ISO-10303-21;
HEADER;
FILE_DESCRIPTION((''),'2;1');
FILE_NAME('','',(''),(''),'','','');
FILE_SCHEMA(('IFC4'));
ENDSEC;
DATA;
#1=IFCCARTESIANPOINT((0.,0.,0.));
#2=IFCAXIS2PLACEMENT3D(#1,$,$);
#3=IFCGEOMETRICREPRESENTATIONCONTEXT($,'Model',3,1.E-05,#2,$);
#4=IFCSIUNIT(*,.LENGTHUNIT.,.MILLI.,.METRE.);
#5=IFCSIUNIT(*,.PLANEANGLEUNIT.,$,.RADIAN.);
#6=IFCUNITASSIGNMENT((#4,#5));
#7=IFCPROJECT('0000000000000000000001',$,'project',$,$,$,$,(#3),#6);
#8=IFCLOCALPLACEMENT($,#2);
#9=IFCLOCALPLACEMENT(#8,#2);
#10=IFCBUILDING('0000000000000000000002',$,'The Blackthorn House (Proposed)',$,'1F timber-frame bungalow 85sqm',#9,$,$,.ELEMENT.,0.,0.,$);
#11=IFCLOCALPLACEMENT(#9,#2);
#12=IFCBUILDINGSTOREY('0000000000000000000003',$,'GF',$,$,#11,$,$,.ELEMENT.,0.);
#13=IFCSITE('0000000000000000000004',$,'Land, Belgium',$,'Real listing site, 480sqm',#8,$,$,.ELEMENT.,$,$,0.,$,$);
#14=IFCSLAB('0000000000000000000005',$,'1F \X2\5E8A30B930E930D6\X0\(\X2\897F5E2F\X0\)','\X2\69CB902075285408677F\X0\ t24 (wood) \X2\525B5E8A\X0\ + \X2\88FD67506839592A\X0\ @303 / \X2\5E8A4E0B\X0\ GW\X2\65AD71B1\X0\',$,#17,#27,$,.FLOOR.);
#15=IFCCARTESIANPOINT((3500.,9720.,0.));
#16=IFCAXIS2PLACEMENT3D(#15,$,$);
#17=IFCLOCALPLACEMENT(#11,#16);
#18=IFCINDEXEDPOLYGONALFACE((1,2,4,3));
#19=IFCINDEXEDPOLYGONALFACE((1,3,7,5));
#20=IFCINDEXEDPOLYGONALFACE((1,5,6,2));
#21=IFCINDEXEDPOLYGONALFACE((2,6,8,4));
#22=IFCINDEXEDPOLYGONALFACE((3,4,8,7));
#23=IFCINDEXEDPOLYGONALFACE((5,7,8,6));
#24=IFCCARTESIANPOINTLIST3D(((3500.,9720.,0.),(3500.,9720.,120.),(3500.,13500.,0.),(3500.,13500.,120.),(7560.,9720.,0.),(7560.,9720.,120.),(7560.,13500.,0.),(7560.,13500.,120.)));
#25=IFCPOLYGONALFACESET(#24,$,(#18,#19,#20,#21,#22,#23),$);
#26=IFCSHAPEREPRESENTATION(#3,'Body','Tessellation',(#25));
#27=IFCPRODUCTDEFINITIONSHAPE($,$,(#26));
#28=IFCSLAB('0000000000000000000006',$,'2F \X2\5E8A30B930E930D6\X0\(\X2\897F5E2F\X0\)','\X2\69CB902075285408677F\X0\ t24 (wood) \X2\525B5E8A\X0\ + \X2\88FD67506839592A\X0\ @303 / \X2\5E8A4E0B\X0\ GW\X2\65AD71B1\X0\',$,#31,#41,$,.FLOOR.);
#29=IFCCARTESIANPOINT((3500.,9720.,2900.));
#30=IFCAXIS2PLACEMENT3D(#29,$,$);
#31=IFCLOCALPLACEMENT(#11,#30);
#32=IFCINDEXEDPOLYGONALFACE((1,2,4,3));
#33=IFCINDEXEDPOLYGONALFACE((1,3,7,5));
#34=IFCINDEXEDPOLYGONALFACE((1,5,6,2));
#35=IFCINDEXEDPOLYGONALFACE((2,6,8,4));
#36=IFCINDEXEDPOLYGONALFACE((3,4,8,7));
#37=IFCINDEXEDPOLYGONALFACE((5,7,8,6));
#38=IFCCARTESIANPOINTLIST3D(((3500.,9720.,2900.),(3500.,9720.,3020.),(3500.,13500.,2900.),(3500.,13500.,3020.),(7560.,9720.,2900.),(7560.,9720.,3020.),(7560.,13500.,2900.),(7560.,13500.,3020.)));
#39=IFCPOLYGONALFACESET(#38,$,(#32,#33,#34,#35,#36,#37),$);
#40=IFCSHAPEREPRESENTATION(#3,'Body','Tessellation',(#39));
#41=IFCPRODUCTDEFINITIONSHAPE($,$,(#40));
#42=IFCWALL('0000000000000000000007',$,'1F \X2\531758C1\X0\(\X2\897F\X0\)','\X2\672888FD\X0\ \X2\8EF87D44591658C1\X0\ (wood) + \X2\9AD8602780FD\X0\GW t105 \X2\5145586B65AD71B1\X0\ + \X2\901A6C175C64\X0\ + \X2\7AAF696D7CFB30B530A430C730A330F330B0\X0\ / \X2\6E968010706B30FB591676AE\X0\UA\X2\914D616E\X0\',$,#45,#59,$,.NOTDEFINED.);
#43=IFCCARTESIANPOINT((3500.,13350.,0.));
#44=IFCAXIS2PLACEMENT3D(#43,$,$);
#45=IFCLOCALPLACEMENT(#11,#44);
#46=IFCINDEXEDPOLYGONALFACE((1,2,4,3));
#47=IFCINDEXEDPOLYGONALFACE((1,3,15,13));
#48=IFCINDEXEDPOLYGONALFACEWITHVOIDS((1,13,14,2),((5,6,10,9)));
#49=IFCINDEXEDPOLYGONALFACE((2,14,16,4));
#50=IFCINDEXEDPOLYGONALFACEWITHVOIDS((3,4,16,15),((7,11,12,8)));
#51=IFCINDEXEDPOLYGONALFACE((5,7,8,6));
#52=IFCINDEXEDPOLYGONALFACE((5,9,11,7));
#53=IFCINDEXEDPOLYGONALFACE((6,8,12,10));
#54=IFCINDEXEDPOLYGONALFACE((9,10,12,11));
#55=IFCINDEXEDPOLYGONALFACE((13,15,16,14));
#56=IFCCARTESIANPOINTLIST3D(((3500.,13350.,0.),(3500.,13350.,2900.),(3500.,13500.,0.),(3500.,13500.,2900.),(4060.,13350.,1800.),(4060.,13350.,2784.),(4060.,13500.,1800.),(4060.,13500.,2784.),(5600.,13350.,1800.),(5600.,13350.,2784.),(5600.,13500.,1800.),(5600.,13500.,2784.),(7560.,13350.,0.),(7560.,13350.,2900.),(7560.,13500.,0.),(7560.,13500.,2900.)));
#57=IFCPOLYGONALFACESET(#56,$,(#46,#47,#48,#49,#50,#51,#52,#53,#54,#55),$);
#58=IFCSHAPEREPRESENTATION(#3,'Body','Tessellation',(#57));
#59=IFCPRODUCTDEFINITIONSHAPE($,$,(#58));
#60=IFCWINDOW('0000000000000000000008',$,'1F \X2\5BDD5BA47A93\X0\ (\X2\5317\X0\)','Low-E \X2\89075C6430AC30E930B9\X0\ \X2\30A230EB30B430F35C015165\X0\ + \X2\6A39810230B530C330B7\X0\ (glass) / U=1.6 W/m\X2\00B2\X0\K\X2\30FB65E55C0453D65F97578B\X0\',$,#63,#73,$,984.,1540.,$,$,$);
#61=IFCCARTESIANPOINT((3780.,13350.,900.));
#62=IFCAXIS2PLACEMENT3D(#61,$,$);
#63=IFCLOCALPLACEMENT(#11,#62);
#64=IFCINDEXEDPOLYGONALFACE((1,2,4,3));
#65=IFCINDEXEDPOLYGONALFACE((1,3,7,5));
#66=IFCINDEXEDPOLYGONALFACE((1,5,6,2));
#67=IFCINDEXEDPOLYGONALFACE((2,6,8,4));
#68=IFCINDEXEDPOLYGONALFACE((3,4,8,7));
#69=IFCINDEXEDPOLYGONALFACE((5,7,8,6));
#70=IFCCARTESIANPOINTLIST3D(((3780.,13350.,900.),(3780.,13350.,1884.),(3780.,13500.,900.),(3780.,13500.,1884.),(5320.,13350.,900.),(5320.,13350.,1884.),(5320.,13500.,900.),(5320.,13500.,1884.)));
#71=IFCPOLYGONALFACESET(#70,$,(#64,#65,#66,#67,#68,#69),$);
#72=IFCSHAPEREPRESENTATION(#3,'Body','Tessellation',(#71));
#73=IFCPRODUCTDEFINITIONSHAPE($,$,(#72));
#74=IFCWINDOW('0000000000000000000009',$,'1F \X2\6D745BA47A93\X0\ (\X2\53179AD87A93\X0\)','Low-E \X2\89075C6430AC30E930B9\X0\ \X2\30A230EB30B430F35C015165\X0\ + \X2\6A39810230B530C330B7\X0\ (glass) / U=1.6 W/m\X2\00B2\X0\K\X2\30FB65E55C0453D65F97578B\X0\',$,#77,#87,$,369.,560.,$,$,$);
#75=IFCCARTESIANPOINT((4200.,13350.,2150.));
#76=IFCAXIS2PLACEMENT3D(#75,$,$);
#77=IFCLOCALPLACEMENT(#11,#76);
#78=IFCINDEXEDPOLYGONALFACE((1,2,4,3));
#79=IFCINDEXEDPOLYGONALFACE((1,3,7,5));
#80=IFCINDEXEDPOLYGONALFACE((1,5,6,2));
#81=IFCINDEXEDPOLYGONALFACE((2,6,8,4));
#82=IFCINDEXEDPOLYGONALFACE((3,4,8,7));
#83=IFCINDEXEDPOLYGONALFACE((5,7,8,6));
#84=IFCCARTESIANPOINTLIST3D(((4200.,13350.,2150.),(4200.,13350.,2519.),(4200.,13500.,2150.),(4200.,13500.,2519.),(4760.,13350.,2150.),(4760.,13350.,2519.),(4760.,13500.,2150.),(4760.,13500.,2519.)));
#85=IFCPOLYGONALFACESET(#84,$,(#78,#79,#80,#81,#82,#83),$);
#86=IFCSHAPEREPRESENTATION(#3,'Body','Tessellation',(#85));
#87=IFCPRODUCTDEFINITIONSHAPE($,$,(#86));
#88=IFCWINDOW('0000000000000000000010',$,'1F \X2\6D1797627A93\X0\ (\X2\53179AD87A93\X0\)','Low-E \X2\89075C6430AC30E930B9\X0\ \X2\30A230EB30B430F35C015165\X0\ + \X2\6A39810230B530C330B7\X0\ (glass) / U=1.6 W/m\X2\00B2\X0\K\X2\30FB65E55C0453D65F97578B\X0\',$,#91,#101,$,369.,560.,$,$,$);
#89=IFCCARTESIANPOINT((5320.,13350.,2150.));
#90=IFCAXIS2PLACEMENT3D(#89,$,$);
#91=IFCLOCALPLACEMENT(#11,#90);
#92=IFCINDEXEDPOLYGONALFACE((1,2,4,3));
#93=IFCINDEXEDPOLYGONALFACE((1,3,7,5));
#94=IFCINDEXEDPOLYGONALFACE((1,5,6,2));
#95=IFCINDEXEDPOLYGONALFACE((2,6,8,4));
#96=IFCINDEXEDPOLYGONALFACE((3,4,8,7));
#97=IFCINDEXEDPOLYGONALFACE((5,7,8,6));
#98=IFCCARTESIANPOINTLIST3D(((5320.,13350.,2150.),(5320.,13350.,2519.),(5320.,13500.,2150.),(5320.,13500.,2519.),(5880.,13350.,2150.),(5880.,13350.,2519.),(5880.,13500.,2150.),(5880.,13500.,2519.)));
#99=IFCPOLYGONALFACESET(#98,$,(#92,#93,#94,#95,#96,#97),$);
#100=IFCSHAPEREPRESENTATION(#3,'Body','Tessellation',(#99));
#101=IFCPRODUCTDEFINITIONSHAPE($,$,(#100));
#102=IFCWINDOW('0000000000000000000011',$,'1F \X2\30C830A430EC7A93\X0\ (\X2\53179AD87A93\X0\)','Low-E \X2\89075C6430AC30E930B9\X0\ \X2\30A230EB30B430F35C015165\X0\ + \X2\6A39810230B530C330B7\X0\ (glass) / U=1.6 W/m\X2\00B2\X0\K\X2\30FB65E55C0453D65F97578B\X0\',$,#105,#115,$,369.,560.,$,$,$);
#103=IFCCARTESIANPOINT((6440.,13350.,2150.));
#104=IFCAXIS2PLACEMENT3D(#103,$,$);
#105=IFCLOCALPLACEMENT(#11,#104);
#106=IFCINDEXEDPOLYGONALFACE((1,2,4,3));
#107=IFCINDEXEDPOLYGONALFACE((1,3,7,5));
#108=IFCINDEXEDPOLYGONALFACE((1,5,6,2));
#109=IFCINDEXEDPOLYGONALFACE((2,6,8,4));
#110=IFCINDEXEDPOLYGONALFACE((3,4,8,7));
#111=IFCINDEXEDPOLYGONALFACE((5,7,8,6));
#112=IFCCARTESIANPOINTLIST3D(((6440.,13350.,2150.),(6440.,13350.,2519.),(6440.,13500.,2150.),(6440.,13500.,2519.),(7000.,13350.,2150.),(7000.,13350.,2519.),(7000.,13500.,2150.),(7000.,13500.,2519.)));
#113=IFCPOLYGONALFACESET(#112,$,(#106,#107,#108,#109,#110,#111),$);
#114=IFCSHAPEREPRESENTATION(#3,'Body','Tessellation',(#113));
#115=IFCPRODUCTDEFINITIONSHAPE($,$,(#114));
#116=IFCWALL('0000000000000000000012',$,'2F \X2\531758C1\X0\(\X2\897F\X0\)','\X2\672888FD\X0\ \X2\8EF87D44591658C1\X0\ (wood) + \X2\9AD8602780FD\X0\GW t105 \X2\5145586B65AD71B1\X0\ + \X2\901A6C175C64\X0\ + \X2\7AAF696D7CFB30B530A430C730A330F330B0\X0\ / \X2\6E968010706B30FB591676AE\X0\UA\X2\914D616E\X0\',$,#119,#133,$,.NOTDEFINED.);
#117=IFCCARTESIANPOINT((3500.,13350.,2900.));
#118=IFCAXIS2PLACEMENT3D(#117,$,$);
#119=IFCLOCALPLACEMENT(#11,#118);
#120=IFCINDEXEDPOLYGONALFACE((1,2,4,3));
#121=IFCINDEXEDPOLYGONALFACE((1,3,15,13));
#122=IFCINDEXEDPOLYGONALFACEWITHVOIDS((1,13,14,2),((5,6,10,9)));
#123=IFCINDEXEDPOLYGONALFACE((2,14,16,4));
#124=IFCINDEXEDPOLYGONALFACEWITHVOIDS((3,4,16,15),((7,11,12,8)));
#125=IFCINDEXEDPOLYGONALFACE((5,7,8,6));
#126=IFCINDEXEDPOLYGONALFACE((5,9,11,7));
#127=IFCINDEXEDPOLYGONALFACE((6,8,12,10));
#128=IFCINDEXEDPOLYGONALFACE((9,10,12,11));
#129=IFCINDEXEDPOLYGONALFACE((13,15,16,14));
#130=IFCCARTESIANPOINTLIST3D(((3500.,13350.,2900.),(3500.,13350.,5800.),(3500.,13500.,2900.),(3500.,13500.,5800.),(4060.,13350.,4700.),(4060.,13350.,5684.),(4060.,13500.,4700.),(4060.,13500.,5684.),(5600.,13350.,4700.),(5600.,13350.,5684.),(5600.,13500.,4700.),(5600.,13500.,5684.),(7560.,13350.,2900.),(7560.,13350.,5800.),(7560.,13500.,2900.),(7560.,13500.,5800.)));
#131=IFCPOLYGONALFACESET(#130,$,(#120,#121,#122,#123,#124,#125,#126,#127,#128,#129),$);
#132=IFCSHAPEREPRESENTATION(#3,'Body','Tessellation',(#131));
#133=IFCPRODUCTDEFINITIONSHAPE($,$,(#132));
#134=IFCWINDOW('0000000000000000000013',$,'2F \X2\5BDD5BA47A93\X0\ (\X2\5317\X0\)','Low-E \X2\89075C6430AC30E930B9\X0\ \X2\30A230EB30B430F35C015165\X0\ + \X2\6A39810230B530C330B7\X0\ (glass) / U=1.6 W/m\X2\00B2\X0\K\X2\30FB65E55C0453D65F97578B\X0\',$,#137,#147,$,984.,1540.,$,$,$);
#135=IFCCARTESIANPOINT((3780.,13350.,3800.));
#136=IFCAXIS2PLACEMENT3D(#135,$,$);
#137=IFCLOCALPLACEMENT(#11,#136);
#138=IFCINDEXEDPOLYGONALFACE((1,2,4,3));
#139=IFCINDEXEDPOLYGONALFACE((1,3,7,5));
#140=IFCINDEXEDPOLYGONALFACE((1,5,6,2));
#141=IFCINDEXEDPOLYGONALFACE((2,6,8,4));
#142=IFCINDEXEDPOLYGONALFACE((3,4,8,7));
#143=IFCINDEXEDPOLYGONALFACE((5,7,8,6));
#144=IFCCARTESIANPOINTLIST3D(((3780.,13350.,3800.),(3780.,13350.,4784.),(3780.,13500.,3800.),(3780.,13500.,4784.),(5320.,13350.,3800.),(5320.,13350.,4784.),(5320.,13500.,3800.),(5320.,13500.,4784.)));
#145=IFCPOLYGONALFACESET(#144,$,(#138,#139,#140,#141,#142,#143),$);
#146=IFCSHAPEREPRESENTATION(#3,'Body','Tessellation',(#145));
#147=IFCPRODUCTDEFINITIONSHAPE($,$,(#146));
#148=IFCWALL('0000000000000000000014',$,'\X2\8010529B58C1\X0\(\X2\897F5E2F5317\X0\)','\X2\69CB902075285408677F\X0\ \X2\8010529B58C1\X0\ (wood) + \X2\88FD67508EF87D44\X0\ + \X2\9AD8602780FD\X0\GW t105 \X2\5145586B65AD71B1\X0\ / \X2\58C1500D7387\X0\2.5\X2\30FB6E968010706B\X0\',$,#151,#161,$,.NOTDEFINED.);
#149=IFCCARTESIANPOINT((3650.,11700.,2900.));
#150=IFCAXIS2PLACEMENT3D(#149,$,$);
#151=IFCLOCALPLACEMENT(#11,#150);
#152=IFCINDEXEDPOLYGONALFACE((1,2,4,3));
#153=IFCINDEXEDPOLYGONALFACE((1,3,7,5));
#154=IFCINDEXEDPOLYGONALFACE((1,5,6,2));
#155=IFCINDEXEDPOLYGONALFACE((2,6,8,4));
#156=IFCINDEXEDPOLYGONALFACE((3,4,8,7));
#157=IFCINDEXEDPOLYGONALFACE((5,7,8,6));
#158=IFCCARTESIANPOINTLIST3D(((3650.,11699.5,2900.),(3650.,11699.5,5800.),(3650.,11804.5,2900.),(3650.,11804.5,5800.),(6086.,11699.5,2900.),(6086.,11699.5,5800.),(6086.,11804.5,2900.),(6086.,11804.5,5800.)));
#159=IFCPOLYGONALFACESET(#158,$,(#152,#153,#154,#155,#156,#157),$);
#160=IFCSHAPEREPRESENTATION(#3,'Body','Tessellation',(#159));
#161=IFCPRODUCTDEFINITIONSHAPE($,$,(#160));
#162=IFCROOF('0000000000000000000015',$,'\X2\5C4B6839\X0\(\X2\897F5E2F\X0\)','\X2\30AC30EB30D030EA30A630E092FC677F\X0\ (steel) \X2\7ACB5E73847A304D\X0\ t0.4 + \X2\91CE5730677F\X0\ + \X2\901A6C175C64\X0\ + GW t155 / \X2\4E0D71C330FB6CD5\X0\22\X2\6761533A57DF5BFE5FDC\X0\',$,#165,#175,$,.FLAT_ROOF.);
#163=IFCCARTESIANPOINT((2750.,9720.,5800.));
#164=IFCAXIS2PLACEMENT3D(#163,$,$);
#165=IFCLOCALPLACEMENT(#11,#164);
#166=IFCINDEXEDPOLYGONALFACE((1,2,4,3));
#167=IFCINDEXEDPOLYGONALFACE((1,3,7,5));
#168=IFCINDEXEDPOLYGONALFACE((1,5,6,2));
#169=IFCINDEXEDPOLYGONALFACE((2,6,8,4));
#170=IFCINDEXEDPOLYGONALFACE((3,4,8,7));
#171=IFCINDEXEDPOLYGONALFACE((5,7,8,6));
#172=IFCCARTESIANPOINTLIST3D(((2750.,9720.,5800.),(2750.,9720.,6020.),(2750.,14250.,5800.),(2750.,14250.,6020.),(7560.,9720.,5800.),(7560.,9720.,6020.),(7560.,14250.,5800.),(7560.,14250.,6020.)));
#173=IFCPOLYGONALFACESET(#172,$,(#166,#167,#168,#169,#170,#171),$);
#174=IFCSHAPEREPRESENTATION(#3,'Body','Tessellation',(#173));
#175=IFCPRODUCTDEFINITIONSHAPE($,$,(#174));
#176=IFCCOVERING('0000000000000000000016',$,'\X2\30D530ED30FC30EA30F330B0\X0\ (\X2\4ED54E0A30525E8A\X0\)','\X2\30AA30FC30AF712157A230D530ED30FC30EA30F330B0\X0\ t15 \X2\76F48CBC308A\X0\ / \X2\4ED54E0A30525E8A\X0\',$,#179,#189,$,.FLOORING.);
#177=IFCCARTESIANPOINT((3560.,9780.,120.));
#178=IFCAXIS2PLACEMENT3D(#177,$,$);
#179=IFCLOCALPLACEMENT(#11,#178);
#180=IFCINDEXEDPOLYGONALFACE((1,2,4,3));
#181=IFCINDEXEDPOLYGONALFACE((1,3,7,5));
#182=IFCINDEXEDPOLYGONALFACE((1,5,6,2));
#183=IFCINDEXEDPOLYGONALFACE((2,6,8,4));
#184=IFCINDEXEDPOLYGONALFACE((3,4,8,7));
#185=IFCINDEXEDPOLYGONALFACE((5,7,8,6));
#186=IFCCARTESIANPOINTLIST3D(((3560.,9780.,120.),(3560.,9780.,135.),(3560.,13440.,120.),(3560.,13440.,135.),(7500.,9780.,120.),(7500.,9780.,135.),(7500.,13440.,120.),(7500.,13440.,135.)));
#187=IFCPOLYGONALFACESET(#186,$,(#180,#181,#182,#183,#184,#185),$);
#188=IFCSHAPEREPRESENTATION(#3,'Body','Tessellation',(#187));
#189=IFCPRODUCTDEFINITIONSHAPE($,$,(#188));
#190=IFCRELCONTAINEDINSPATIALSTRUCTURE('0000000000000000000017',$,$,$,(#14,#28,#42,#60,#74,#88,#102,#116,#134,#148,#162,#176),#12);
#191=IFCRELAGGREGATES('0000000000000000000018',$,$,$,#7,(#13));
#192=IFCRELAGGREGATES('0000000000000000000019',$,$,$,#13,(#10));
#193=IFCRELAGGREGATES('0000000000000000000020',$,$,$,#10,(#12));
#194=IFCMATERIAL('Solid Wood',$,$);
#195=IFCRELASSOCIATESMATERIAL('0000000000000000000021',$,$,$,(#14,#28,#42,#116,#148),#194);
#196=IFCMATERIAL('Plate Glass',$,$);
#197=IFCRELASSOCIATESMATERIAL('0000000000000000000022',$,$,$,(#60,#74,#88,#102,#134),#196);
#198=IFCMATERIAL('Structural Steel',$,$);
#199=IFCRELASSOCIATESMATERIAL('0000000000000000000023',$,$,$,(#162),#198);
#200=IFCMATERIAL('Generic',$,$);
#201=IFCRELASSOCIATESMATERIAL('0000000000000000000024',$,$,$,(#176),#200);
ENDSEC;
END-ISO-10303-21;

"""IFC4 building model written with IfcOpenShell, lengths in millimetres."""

from ifc_helpers import new_model, si_unit, frame, frame_2d, origin, place, context, project, spatial, rectangle, extrude, material, element, fill, save


model = new_model("IFC4")

# Units and contexts
model_context = context("Model", 3, precision=1e-05, world=origin())
ifc_project = project(units=[si_unit("LENGTHUNIT", "METRE", prefix="MILLI"), si_unit("PLANEANGLEUNIT", "RADIAN")], contexts=[model_context])

# Site, building, storey
site_placement = place(None, origin())
site = spatial("IfcSite", under=ifc_project, at=site_placement, Name="Land, Belgium", ObjectType="Real listing site, 480sqm", CompositionType="ELEMENT", RefElevation=0.0)
building_placement = place(site_placement, origin())
building = spatial("IfcBuilding", under=site, at=building_placement, Name="The Blackthorn House (Proposed)", ObjectType="1F timber-frame bungalow 85sqm", CompositionType="ELEMENT", ElevationOfRefHeight=0.0, ElevationOfTerrain=0.0)
storey_placement = place(building_placement, origin())
storey = spatial("IfcBuildingStorey", under=building, at=storey_placement, Name="GF", CompositionType="ELEMENT", Elevation=0.0)

# Slabs
ifc_material_1 = material(Name="Solid Wood")
slab_1_placement = place(storey_placement, frame((3500.0, 9720.0, 0.0)))
element("IfcSlab", 1, at=slab_1_placement, inside=storey, material=ifc_material_1, Name="1F 床スラブ(西帯)", Description="構造用合板 t24 (wood) 剛床 + 製材根太 @303 / 床下 GW断熱", PredefinedType="FLOOR", context=model_context, shape_type="SweptSolid", body=[
    extrude(rectangle(XDim=4060.0, YDim=3780.0, at=frame_2d((2030.0, 1890.0))), frame((3500.0, 9720.0, 0.0)), (0.0, 0.0, 1.0), 120.0),
])
slab_2_placement = place(storey_placement, frame((3500.0, 9720.0, 2900.0)))
element("IfcSlab", 2, at=slab_2_placement, inside=storey, material=ifc_material_1, Name="2F 床スラブ(西帯)", Description="構造用合板 t24 (wood) 剛床 + 製材根太 @303 / 床下 GW断熱", PredefinedType="FLOOR", context=model_context, shape_type="SweptSolid", body=[
    extrude(rectangle(XDim=4060.0, YDim=3780.0, at=frame_2d((2030.0, 1890.0))), frame((3500.0, 9720.0, 2900.0)), (0.0, 0.0, 1.0), 120.0),
])

# Wall, openings, windows
wall_1_placement = place(storey_placement, frame((3500.0, 13350.0, 0.0)))
wall_1 = element("IfcWall", 3, at=wall_1_placement, inside=storey, material=ifc_material_1, Name="1F 北壁(西)", Description="木製 軸組外壁 (wood) + 高性能GW t105 充填断熱 + 通気層 + 窯業系サイディング / 準耐火・外皮UA配慮", PredefinedType="NOTDEFINED", context=model_context, shape_type="SweptSolid", body=[
    extrude(rectangle(XDim=4060.0, YDim=150.0, at=frame_2d((2030.0, 75.0))), frame((3500.0, 13350.0, 0.0)), (0.0, 0.0, 1.0), 2900.0),
])
opening_1_placement = place(storey_placement, frame((3780.0, 13350.0, 900.0)))
opening_1 = element("IfcOpeningElement", 4, at=opening_1_placement, cuts=wall_1, PredefinedType="NOTDEFINED", context=model_context, shape_type="SweptSolid", body=[
    extrude(rectangle(XDim=1540.0, YDim=150.0, at=frame_2d((770.0, 75.0))), frame((3780.0, 13350.0, 900.0)), (0.0, 0.0, 1.0), 984.0),
])
opening_2_placement = place(storey_placement, frame((4200.0, 13350.0, 2150.0)))
opening_2 = element("IfcOpeningElement", 5, at=opening_2_placement, cuts=wall_1, PredefinedType="NOTDEFINED", context=model_context, shape_type="SweptSolid", body=[
    extrude(rectangle(XDim=560.0, YDim=150.0, at=frame_2d((280.0, 75.0))), frame((4200.0, 13350.0, 2150.0)), (0.0, 0.0, 1.0), 369.0),
])
opening_3_placement = place(storey_placement, frame((5320.0, 13350.0, 2150.0)))
opening_3 = element("IfcOpeningElement", 6, at=opening_3_placement, cuts=wall_1, PredefinedType="NOTDEFINED", context=model_context, shape_type="SweptSolid", body=[
    extrude(rectangle(XDim=560.0, YDim=150.0, at=frame_2d((280.0, 75.0))), frame((5320.0, 13350.0, 2150.0)), (0.0, 0.0, 1.0), 369.0),
])
opening_4_placement = place(storey_placement, frame((6440.0, 13350.0, 2150.0)))
opening_4 = element("IfcOpeningElement", 7, at=opening_4_placement, cuts=wall_1, PredefinedType="NOTDEFINED", context=model_context, shape_type="SweptSolid", body=[
    extrude(rectangle(XDim=560.0, YDim=150.0, at=frame_2d((280.0, 75.0))), frame((6440.0, 13350.0, 2150.0)), (0.0, 0.0, 1.0), 369.0),
])
ifc_material_2 = material(Name="Plate Glass")
window_1_placement = place(storey_placement, frame((3780.0, 13350.0, 900.0)))
window_1 = element("IfcWindow", 8, at=window_1_placement, inside=storey, material=ifc_material_2, Name="1F 寝室窓 (北)", Description="Low-E 複層ガラス アルゴン封入 + 樹脂サッシ (glass) / U=1.6 W/m²K・日射取得型", OverallHeight=984.0, OverallWidth=1540.0, context=model_context, shape_type="SweptSolid", body=[
    extrude(rectangle(XDim=1540.0, YDim=150.0, at=frame_2d((770.0, 75.0))), frame((3780.0, 13350.0, 900.0)), (0.0, 0.0, 1.0), 984.0),
])
fill(opening_1, window_1)
window_2_placement = place(storey_placement, frame((4200.0, 13350.0, 2150.0)))
window_2 = element("IfcWindow", 9, at=window_2_placement, inside=storey, material=ifc_material_2, Name="1F 浴室窓 (北高窓)", Description="Low-E 複層ガラス アルゴン封入 + 樹脂サッシ (glass) / U=1.6 W/m²K・日射取得型", OverallHeight=369.0, OverallWidth=560.0, context=model_context, shape_type="SweptSolid", body=[
    extrude(rectangle(XDim=560.0, YDim=150.0, at=frame_2d((280.0, 75.0))), frame((4200.0, 13350.0, 2150.0)), (0.0, 0.0, 1.0), 369.0),
])
fill(opening_2, window_2)
window_3_placement = place(storey_placement, frame((5320.0, 13350.0, 2150.0)))
window_3 = element("IfcWindow", 10, at=window_3_placement, inside=storey, material=ifc_material_2, Name="1F 洗面窓 (北高窓)", Description="Low-E 複層ガラス アルゴン封入 + 樹脂サッシ (glass) / U=1.6 W/m²K・日射取得型", OverallHeight=369.0, OverallWidth=560.0, context=model_context, shape_type="SweptSolid", body=[
    extrude(rectangle(XDim=560.0, YDim=150.0, at=frame_2d((280.0, 75.0))), frame((5320.0, 13350.0, 2150.0)), (0.0, 0.0, 1.0), 369.0),
])
fill(opening_3, window_3)
window_4_placement = place(storey_placement, frame((6440.0, 13350.0, 2150.0)))
window_4 = element("IfcWindow", 11, at=window_4_placement, inside=storey, material=ifc_material_2, Name="1F トイレ窓 (北高窓)", Description="Low-E 複層ガラス アルゴン封入 + 樹脂サッシ (glass) / U=1.6 W/m²K・日射取得型", OverallHeight=369.0, OverallWidth=560.0, context=model_context, shape_type="SweptSolid", body=[
    extrude(rectangle(XDim=560.0, YDim=150.0, at=frame_2d((280.0, 75.0))), frame((6440.0, 13350.0, 2150.0)), (0.0, 0.0, 1.0), 369.0),
])
fill(opening_4, window_4)

# Wall, opening, window
wall_2_placement = place(storey_placement, frame((3500.0, 13350.0, 2900.0)))
wall_2 = element("IfcWall", 12, at=wall_2_placement, inside=storey, material=ifc_material_1, Name="2F 北壁(西)", Description="木製 軸組外壁 (wood) + 高性能GW t105 充填断熱 + 通気層 + 窯業系サイディング / 準耐火・外皮UA配慮", PredefinedType="NOTDEFINED", context=model_context, shape_type="SweptSolid", body=[
    extrude(rectangle(XDim=4060.0, YDim=150.0, at=frame_2d((2030.0, 75.0))), frame((3500.0, 13350.0, 2900.0)), (0.0, 0.0, 1.0), 2900.0),
])
opening_5_placement = place(storey_placement, frame((3780.0, 13350.0, 3800.0)))
opening_5 = element("IfcOpeningElement", 13, at=opening_5_placement, cuts=wall_2, PredefinedType="NOTDEFINED", context=model_context, shape_type="SweptSolid", body=[
    extrude(rectangle(XDim=1540.0, YDim=150.0, at=frame_2d((770.0, 75.0))), frame((3780.0, 13350.0, 3800.0)), (0.0, 0.0, 1.0), 984.0),
])
window_5_placement = place(storey_placement, frame((3780.0, 13350.0, 3800.0)))
window_5 = element("IfcWindow", 14, at=window_5_placement, inside=storey, material=ifc_material_2, Name="2F 寝室窓 (北)", Description="Low-E 複層ガラス アルゴン封入 + 樹脂サッシ (glass) / U=1.6 W/m²K・日射取得型", OverallHeight=984.0, OverallWidth=1540.0, context=model_context, shape_type="SweptSolid", body=[
    extrude(rectangle(XDim=1540.0, YDim=150.0, at=frame_2d((770.0, 75.0))), frame((3780.0, 13350.0, 3800.0)), (0.0, 0.0, 1.0), 984.0),
])
fill(opening_5, window_5)

# Wall
wall_3_placement = place(storey_placement, frame((3650.0, 11700.0, 2900.0)))
element("IfcWall", 15, at=wall_3_placement, inside=storey, material=ifc_material_1, Name="耐力壁(西帯北)", Description="構造用合板 耐力壁 (wood) + 製材軸組 + 高性能GW t105 充填断熱 / 壁倍率2.5・準耐火", PredefinedType="NOTDEFINED", context=model_context, shape_type="SweptSolid", body=[
    extrude(rectangle(XDim=2436.0, YDim=105.0, at=frame_2d((1218.0, 52.0))), frame((3650.0, 11700.0, 2900.0)), (0.0, 0.0, 1.0), 2900.0),
])

# Roof
ifc_material_3 = material(Name="Structural Steel")
for number, where, name in (
    (16, (2750.0, 9720.0, 5800.0), "屋根(西帯)"),
):
    element("IfcRoof", number, at=place(storey_placement, frame(where)), inside=storey, material=ifc_material_3, Name=name, Description="ガルバリウム鋼板 (steel) 立平葺き t0.4 + 野地板 + 通気層 + GW t155 / 不燃・法22条区域対応", PredefinedType="FLAT_ROOF", context=model_context, shape_type="SweptSolid", body=[
        extrude(rectangle(XDim=4810.0, YDim=4530.0, at=frame_2d((2405.0, 2265.0))), frame((2750.0, 9720.0, 5800.0)), (0.0, 0.0, 1.0), 220.0),
    ])

# Covering
ifc_material_4 = material(Name="Generic")
covering_1_placement = place(storey_placement, frame((3560.0, 9780.0, 120.0)))
element("IfcCovering", 17, at=covering_1_placement, inside=storey, material=ifc_material_4, Name="フローリング (仕上げ床)", Description="オーク無垢フローリング t15 直貼り / 仕上げ床", PredefinedType="FLOORING", context=model_context, shape_type="SweptSolid", body=[
    extrude(rectangle(XDim=3940.0, YDim=3660.0, at=frame_2d((1970.0, 1830.0))), frame((3560.0, 9780.0, 120.0)), (0.0, 0.0, 1.0), 15.0),
])

save(model, "model.ifc")
